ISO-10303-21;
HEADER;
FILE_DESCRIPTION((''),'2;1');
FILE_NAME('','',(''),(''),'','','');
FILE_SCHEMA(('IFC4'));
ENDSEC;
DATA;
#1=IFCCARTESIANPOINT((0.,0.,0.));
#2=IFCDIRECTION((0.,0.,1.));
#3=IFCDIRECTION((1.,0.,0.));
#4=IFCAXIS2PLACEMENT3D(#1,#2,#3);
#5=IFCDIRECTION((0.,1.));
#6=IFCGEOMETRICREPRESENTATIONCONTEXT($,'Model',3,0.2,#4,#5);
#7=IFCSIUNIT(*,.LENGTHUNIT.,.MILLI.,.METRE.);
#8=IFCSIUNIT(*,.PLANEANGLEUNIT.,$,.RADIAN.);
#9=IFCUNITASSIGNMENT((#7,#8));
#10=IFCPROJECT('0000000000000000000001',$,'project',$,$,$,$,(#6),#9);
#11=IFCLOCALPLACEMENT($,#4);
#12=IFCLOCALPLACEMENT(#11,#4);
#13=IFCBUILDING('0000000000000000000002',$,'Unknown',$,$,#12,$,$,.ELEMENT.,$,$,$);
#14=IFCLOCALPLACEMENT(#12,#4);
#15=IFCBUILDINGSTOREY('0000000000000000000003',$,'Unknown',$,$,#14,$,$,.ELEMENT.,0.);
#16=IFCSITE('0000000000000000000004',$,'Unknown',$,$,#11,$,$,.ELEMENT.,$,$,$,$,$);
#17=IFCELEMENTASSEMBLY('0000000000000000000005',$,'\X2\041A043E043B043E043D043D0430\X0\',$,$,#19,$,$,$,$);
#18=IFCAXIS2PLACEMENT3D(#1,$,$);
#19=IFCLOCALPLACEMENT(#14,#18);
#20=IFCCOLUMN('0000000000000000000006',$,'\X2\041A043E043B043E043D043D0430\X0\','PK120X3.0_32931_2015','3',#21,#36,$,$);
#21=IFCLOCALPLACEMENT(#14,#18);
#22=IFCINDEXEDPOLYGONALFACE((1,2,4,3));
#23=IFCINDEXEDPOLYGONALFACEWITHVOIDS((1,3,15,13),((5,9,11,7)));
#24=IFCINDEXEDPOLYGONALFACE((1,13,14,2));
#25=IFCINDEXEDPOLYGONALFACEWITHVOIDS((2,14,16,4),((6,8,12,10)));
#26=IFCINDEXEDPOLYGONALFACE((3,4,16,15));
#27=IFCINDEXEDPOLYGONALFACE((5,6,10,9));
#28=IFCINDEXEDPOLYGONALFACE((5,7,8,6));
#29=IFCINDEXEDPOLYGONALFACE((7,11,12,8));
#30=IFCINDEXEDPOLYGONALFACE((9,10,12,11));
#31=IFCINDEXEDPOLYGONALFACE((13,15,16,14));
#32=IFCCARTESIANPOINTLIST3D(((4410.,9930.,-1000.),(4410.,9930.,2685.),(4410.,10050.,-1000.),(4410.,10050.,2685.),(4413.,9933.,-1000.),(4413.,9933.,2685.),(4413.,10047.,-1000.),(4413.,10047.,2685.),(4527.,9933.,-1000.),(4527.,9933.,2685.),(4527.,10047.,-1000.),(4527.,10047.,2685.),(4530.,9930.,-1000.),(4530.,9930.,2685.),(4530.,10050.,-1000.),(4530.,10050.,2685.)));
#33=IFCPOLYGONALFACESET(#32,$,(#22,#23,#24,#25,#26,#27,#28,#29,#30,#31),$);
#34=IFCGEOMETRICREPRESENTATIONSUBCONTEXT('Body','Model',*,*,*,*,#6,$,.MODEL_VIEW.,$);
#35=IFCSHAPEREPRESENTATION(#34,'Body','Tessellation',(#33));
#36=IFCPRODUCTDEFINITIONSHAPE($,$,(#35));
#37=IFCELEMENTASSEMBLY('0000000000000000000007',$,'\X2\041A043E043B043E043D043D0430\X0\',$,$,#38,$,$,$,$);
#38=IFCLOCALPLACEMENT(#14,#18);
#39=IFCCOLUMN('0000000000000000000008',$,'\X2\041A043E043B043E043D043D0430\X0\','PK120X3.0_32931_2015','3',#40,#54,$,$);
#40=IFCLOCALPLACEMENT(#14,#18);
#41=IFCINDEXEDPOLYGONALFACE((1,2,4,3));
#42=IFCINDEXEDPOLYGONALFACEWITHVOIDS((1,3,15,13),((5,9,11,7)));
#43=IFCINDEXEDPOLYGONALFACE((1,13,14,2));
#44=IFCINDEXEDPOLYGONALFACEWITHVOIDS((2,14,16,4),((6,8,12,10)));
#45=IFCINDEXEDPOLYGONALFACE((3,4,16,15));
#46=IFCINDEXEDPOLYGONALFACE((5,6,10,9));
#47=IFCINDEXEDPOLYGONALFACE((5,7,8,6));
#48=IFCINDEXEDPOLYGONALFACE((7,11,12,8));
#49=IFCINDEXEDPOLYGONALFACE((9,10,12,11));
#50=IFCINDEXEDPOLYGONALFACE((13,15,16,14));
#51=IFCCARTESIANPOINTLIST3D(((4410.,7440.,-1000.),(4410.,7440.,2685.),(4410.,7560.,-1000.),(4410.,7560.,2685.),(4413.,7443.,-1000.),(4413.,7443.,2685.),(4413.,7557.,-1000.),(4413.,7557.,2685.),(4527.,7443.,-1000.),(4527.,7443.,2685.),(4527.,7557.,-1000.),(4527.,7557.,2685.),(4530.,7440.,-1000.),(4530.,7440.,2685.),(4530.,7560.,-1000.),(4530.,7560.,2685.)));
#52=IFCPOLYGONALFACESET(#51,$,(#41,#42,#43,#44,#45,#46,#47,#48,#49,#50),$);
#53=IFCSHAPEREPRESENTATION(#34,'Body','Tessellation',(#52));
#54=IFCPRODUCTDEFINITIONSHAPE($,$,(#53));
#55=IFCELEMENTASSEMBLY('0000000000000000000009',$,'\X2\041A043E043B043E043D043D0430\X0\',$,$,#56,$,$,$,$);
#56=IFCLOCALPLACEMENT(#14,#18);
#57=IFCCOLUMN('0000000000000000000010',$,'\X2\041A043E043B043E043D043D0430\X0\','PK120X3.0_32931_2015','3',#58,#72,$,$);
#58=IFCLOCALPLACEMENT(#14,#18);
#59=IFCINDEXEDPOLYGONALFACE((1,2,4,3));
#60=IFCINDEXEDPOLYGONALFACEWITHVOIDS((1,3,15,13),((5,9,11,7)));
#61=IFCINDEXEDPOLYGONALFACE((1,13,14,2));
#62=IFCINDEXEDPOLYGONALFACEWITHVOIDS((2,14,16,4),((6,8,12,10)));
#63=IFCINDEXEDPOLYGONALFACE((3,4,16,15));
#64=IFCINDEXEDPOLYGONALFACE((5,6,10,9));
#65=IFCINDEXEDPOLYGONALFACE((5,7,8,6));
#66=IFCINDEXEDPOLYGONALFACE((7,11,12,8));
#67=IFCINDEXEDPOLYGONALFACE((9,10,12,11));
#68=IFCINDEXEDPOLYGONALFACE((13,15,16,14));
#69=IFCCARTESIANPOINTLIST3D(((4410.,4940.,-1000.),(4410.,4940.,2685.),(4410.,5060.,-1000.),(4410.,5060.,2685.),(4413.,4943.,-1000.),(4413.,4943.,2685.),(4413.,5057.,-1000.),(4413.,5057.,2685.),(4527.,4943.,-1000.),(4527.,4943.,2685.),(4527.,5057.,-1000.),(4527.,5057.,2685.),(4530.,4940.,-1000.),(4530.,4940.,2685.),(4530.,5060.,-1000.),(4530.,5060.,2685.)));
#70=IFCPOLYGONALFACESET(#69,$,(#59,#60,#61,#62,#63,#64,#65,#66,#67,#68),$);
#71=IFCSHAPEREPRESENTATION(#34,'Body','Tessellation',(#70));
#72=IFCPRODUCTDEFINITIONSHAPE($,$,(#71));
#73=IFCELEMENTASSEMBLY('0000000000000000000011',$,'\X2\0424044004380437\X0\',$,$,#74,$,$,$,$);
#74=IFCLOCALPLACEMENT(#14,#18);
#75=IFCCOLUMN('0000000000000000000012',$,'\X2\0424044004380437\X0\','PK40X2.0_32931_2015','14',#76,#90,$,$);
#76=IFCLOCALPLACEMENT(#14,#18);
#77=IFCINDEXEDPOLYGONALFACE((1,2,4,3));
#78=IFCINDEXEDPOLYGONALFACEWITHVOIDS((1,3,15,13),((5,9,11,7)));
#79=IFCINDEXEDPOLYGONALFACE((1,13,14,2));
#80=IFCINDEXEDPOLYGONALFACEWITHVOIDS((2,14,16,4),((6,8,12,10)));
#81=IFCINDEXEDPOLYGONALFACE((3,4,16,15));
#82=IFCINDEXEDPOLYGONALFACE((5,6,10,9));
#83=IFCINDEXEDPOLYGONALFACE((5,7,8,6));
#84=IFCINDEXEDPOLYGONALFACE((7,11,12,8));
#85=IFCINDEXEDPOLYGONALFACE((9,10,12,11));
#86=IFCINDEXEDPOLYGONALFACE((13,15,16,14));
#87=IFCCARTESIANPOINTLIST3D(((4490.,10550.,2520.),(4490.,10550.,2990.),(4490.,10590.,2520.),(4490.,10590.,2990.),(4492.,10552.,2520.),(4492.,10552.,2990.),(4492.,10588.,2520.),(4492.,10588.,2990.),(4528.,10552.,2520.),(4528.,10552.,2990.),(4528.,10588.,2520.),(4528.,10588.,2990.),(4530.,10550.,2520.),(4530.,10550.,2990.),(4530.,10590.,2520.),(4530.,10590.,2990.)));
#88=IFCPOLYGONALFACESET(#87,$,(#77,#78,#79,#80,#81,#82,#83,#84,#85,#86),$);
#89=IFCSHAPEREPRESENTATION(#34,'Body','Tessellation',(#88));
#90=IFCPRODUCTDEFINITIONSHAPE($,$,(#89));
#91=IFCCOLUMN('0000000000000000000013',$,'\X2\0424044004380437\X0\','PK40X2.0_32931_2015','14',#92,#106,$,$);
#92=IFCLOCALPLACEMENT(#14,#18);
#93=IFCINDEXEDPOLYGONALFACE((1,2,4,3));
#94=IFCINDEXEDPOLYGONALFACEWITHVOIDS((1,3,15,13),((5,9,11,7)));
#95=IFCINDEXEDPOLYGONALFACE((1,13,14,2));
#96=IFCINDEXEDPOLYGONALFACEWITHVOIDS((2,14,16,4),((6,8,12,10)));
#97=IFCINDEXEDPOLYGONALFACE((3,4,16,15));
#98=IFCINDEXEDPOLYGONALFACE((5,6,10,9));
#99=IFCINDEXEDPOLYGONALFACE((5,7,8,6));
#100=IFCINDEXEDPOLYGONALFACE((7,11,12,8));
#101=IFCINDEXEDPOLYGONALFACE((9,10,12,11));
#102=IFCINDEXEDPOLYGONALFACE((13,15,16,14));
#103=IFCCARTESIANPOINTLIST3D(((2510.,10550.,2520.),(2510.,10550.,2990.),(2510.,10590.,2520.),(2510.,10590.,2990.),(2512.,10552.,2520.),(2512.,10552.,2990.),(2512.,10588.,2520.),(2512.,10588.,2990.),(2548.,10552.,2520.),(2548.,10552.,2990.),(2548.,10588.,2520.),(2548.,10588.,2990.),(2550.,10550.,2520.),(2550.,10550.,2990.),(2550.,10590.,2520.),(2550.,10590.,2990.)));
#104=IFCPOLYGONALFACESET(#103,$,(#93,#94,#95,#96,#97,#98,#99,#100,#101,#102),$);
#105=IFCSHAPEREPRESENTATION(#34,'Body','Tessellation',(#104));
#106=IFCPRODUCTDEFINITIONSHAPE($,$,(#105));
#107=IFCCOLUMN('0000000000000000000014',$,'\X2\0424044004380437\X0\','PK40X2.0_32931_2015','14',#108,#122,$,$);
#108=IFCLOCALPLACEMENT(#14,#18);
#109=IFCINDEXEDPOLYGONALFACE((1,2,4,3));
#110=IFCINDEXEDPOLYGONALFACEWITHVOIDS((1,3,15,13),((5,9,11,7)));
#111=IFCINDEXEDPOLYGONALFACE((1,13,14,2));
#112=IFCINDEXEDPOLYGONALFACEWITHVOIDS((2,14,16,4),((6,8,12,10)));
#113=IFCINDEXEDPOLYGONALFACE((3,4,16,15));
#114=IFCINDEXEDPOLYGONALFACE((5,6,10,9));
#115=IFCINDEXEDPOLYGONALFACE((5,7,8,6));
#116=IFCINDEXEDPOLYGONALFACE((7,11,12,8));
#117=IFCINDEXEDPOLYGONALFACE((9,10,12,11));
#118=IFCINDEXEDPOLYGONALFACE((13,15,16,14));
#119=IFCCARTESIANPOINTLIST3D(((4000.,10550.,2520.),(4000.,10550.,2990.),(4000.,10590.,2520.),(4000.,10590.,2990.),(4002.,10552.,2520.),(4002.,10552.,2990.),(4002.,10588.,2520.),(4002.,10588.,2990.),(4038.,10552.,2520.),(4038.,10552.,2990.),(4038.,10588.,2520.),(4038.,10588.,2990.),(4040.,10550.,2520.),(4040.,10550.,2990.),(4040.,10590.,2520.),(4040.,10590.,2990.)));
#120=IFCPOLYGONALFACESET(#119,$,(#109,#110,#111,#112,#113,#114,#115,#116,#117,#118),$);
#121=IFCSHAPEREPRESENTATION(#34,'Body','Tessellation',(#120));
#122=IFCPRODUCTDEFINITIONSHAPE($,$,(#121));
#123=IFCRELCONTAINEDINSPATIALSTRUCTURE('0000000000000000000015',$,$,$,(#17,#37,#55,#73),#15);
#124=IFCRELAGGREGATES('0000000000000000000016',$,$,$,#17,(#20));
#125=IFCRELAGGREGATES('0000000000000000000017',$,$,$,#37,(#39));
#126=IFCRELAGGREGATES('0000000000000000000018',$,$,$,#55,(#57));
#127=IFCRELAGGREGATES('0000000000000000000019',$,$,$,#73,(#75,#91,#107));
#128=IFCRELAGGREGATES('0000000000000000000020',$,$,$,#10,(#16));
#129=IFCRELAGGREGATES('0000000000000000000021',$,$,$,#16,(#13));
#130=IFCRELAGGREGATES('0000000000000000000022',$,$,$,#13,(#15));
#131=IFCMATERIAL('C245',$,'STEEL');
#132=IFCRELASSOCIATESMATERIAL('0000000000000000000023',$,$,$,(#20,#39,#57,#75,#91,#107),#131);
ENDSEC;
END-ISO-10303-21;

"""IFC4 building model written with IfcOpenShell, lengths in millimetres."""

from ifc_helpers import new_model, si_unit, direction, frame, origin_with_axes, place, context, subcontext, project, spatial, line, indexed_curve, outline, extrude, material, element, aggregate, save


model = new_model("IFC4")

# Units and contexts
model_context = context("Model", 3, precision=0.2, world=origin_with_axes(), true_north=direction((0.0, 1.0)))
body_context = subcontext(model_context, "Body", "Model", "MODEL_VIEW")
ifc_project = project(units=[si_unit("LENGTHUNIT", "METRE", prefix="MILLI"), si_unit("PLANEANGLEUNIT", "RADIAN")], contexts=[model_context])

# Site, building, storey
site_placement = place(None, origin_with_axes())
site = spatial("IfcSite", under=ifc_project, at=site_placement, Name="Unknown", CompositionType="ELEMENT")
building_placement = place(site_placement, origin_with_axes())
building = spatial("IfcBuilding", under=site, at=building_placement, Name="Unknown", CompositionType="ELEMENT")
storey_placement = place(building_placement, origin_with_axes())
storey = spatial("IfcBuildingStorey", under=building, at=storey_placement, Name="Unknown", CompositionType="ELEMENT", Elevation=0.0)

# Element assemblies, columns
assembly_1_placement = place(storey_placement, frame((4470.0, 9990.0, -1000.0), z_axis=(-1.0, 0.0, 0.0), x_axis=(0.0, 0.0, 1.0)))
assembly_1 = element("IfcElementAssembly", 1, at=assembly_1_placement, inside=storey, Name="Колонна")
ifc_material_1 = material(Name="C245", Category="STEEL")
column_1_placement = place(assembly_1_placement, origin_with_axes())
column_1 = element("IfcColumn", 2, at=column_1_placement, material=ifc_material_1, Name="Колонна", Description="PK120X3.0_32931_2015", ObjectType="3", context=body_context, shape_type="SolidModel", body=[
    extrude(outline(indexed_curve([(-60.0, -60.0), (60.0, -60.0), (60.0, 60.0), (-60.0, 60.0)], segments=[line(1, 2, 3, 4, 1)]), holes=[indexed_curve([(-57.0, -57.0), (-57.0, 57.0), (57.0, 57.0), (57.0, -57.0)], segments=[line(1, 2, 3, 4, 1)])]), frame((0.0, 0.0, 0.0), z_axis=(-1.0, 0.0, 0.0), x_axis=(0.0, 0.0, 1.0)), (0.0, 0.0, -1.0), 3685.0),
])
aggregate(assembly_1, [column_1])
placement_1 = place(storey_placement, frame((4470.0, 7500.0, -1000.0), z_axis=(-1.0, 0.0, 0.0), x_axis=(0.0, 0.0, 1.0)))
assembly_2 = element("IfcElementAssembly", 3, at=placement_1, inside=storey, Name="Колонна")
placement_2 = place(placement_1, origin_with_axes())
column_2 = element("IfcColumn", 4, at=placement_2, material=ifc_material_1, Name="Колонна", Description="PK120X3.0_32931_2015", ObjectType="3", context=body_context, shape_type="SolidModel", body=[
    extrude(outline(indexed_curve([(-60.0, -60.0), (60.0, -60.0), (60.0, 60.0), (-60.0, 60.0)], segments=[line(1, 2, 3, 4, 1)]), holes=[indexed_curve([(-57.0, -57.0), (-57.0, 57.0), (57.0, 57.0), (57.0, -57.0)], segments=[line(1, 2, 3, 4, 1)])]), frame((0.0, 0.0, 0.0), z_axis=(-1.0, 0.0, 0.0), x_axis=(0.0, 0.0, 1.0)), (0.0, 0.0, -1.0), 3685.0),
])
aggregate(assembly_2, [column_2])
placement_3 = place(storey_placement, frame((4470.0, 5000.0, -1000.0), z_axis=(-1.0, 0.0, 0.0), x_axis=(0.0, 0.0, 1.0)))
assembly_3 = element("IfcElementAssembly", 5, at=placement_3, inside=storey, Name="Колонна")
placement_4 = place(placement_3, origin_with_axes())
column_3 = element("IfcColumn", 6, at=placement_4, material=ifc_material_1, Name="Колонна", Description="PK120X3.0_32931_2015", ObjectType="3", context=body_context, shape_type="SolidModel", body=[
    extrude(outline(indexed_curve([(-60.0, -60.0), (60.0, -60.0), (60.0, 60.0), (-60.0, 60.0)], segments=[line(1, 2, 3, 4, 1)]), holes=[indexed_curve([(-57.0, -57.0), (-57.0, 57.0), (57.0, 57.0), (57.0, -57.0)], segments=[line(1, 2, 3, 4, 1)])]), frame((0.0, 0.0, 0.0), z_axis=(-1.0, 0.0, 0.0), x_axis=(0.0, 0.0, 1.0)), (0.0, 0.0, -1.0), 3685.0),
])
aggregate(assembly_3, [column_3])

# Element assembly, columns
assembly_4_placement = place(storey_placement, frame((-470.0, 10570.0, 3010.0), z_axis=(0.0, -1.0, 0.0), x_axis=(1.0, 0.0, 0.0)))
assembly_4 = element("IfcElementAssembly", 7, at=assembly_4_placement, inside=storey, Name="Фриз")
column_4_placement = place(assembly_4_placement, frame((4980.0, -490.0, 0.0), z_axis=(0.0, 0.0, 1.0), x_axis=(0.0, 1.0, 0.0)))
column_4 = element("IfcColumn", 8, at=column_4_placement, material=ifc_material_1, Name="Фриз", Description="PK40X2.0_32931_2015", ObjectType="14", context=body_context, shape_type="SolidModel", body=[
    extrude(outline(indexed_curve([(-20.0, -20.0), (20.0, -20.0), (20.0, 20.0), (-20.0, 20.0)], segments=[line(1, 2, 3, 4, 1)]), holes=[indexed_curve([(-18.0, -18.0), (-18.0, 18.0), (18.0, 18.0), (18.0, -18.0)], segments=[line(1, 2, 3, 4, 1)])]), frame((0.0, 0.0, 0.0), z_axis=(-1.0, 0.0, 0.0), x_axis=(0.0, 0.0, 1.0)), (0.0, 0.0, -1.0), 470.0),
])
column_5_placement = place(assembly_4_placement, frame((3000.0, -490.0, 0.0), z_axis=(0.0, 0.0, -1.0), x_axis=(0.0, 1.0, 0.0)))
column_5 = element("IfcColumn", 9, at=column_5_placement, material=ifc_material_1, Name="Фриз", Description="PK40X2.0_32931_2015", ObjectType="14", context=body_context, shape_type="SolidModel", body=[
    extrude(outline(indexed_curve([(-20.0, -20.0), (20.0, -20.0), (20.0, 20.0), (-20.0, 20.0)], segments=[line(1, 2, 3, 4, 1)]), holes=[indexed_curve([(-18.0, -18.0), (-18.0, 18.0), (18.0, 18.0), (18.0, -18.0)], segments=[line(1, 2, 3, 4, 1)])]), frame((0.0, 0.0, 0.0), z_axis=(-1.0, 0.0, 0.0), x_axis=(0.0, 0.0, 1.0)), (0.0, 0.0, -1.0), 470.0),
])
column_6_placement = place(assembly_4_placement, frame((4490.0, -490.0, 0.0), z_axis=(0.0, 0.0, -1.0), x_axis=(0.0, 1.0, 0.0)))
column_6 = element("IfcColumn", 10, at=column_6_placement, material=ifc_material_1, Name="Фриз", Description="PK40X2.0_32931_2015", ObjectType="14", context=body_context, shape_type="SolidModel", body=[
    extrude(outline(indexed_curve([(-20.0, -20.0), (20.0, -20.0), (20.0, 20.0), (-20.0, 20.0)], segments=[line(1, 2, 3, 4, 1)]), holes=[indexed_curve([(-18.0, -18.0), (-18.0, 18.0), (18.0, 18.0), (18.0, -18.0)], segments=[line(1, 2, 3, 4, 1)])]), frame((0.0, 0.0, 0.0), z_axis=(-1.0, 0.0, 0.0), x_axis=(0.0, 0.0, 1.0)), (0.0, 0.0, -1.0), 470.0),
])
aggregate(assembly_4, [column_4, column_5, column_6])

save(model, "model.ifc")
